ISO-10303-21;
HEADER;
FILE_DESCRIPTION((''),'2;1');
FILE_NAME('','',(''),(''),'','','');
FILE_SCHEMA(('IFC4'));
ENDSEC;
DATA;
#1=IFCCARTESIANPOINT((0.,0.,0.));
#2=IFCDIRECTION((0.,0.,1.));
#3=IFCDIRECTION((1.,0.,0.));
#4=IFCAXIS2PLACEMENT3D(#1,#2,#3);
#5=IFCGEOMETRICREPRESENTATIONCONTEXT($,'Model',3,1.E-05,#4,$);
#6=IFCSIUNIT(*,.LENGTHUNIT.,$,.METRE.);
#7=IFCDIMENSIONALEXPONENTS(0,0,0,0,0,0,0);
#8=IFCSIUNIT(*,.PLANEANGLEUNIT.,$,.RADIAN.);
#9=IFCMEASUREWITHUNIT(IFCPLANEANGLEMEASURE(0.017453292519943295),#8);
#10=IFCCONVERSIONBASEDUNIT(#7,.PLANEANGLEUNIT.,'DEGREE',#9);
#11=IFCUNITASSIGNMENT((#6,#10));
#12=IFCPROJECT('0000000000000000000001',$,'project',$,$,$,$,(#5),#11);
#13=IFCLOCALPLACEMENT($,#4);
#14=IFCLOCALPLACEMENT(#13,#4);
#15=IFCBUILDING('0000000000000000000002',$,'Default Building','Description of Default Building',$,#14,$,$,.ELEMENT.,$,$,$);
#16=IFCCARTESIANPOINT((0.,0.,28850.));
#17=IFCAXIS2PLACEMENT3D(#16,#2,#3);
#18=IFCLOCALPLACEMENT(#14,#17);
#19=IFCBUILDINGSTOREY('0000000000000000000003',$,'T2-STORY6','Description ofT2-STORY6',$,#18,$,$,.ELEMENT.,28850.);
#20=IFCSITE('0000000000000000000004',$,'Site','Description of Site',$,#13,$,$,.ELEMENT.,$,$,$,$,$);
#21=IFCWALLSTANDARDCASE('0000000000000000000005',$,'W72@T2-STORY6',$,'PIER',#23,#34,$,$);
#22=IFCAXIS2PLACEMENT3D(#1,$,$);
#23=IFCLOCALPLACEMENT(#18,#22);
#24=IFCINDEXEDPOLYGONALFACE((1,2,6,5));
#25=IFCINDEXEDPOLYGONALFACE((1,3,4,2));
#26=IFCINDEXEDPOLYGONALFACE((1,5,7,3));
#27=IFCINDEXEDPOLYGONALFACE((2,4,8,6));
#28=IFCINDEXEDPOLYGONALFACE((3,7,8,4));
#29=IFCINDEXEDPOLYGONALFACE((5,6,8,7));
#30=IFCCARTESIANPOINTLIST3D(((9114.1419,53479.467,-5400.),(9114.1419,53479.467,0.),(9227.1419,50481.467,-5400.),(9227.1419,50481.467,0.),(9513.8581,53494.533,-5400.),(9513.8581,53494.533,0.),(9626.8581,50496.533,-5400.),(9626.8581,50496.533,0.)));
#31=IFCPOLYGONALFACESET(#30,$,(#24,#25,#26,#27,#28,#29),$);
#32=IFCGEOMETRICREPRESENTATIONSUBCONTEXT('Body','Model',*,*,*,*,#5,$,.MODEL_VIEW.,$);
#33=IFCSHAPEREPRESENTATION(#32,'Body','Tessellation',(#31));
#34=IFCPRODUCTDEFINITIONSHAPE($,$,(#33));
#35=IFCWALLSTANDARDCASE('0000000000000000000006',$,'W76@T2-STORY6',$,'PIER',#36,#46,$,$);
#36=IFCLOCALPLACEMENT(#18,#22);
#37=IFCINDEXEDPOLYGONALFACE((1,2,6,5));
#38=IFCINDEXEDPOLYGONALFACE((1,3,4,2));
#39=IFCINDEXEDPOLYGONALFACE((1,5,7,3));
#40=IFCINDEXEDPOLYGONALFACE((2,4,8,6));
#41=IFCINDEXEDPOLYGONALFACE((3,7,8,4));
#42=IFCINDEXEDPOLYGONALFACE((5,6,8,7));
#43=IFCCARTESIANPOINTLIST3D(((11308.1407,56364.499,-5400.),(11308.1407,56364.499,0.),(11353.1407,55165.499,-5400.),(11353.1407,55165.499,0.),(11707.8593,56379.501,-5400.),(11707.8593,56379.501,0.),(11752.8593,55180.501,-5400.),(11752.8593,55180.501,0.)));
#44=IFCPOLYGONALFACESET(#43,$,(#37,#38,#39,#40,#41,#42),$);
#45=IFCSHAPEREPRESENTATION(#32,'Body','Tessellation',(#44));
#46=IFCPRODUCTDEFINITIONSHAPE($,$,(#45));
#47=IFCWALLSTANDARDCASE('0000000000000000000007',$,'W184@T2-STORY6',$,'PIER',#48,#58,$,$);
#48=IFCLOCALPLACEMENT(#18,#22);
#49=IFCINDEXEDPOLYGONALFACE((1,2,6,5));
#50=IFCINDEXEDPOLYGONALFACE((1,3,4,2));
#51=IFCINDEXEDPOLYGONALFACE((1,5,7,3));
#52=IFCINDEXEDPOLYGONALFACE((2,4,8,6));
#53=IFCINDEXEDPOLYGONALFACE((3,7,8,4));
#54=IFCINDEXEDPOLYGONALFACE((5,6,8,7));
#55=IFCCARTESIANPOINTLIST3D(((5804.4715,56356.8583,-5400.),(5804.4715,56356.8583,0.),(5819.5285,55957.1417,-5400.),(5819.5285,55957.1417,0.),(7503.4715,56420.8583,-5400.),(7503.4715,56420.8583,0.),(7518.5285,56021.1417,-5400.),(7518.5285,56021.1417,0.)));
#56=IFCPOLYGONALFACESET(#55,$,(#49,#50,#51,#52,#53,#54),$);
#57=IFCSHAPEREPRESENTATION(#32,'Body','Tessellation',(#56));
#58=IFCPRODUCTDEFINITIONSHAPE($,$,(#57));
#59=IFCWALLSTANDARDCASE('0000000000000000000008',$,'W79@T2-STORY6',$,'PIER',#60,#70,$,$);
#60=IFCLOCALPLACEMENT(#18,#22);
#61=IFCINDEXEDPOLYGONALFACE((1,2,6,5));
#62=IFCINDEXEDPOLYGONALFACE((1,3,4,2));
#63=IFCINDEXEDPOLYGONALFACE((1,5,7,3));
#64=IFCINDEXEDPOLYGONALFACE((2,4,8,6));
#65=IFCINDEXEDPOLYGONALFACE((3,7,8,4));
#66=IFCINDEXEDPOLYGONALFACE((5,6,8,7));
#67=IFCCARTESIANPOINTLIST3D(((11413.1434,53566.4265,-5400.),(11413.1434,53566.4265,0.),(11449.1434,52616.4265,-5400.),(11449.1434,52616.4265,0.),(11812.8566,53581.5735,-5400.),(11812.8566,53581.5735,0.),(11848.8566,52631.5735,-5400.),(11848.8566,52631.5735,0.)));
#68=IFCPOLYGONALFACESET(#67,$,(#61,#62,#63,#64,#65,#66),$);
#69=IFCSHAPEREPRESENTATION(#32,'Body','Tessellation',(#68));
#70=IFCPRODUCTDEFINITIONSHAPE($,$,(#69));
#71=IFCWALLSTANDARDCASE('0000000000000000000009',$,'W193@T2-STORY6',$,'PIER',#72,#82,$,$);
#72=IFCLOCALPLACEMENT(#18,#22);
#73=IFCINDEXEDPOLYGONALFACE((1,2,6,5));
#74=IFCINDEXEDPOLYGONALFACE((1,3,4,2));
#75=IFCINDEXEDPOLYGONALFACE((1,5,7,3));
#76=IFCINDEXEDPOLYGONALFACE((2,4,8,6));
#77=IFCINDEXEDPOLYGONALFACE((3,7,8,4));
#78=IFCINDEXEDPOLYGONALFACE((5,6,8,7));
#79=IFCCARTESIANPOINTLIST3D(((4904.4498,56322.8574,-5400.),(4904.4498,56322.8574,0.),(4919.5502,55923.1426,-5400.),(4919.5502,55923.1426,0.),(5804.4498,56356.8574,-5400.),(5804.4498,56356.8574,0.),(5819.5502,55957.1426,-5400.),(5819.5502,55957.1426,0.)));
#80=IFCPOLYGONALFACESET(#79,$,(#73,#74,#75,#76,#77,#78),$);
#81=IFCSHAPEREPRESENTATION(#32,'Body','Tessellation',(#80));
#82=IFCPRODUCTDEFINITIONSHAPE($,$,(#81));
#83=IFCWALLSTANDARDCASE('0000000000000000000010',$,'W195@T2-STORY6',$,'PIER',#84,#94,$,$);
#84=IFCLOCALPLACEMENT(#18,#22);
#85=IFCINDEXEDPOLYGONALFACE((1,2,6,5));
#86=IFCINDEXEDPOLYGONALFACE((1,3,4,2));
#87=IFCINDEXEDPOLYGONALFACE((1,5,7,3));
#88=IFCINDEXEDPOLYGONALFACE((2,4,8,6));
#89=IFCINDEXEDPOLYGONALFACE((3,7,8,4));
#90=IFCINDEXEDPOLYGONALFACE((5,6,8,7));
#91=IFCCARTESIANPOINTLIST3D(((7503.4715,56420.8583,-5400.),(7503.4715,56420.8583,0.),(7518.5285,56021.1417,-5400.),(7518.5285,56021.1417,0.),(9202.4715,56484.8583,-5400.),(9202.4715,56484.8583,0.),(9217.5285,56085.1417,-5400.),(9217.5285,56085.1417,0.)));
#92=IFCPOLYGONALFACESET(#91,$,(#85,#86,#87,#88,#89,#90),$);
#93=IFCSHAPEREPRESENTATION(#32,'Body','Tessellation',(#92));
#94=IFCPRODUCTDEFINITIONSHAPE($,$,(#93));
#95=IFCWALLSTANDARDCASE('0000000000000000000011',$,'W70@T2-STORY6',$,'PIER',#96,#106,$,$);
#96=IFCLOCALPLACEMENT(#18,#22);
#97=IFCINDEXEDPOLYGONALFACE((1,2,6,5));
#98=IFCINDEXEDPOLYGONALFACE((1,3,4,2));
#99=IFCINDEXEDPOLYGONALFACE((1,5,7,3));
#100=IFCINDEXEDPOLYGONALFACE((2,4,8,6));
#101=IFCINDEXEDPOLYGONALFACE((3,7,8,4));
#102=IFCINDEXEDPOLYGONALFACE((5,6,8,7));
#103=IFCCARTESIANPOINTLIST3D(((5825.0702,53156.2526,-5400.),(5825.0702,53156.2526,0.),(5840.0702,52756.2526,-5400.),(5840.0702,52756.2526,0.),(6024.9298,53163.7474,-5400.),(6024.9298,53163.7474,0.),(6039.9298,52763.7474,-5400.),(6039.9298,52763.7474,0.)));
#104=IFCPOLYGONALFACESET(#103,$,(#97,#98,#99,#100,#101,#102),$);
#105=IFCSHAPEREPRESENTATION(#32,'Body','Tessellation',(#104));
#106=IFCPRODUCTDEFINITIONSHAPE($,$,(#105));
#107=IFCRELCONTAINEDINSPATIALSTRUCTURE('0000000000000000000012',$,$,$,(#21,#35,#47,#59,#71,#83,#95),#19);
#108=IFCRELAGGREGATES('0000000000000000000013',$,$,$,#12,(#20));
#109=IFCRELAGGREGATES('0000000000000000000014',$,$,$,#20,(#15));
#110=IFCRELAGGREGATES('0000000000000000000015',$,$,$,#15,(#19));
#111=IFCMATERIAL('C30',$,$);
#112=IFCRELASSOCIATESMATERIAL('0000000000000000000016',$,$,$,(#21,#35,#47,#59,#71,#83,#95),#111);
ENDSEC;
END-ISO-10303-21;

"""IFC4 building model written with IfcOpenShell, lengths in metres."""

from ifc_helpers import new_model, entity, si_unit, converted_unit, frame, origin_with_axes, place, context, subcontext, project, spatial, indexed_curve, outline, extrude, material, element, save


model = new_model("IFC4")

# Units and contexts
model_context = context("Model", 3, precision=1e-05, world=origin_with_axes())
body_context = subcontext(model_context, "Body", "Model", "MODEL_VIEW")
ifc_project = project(units=[si_unit("LENGTHUNIT", "METRE"), converted_unit("PLANEANGLEUNIT", "DEGREE", entity("IfcPlaneAngleMeasure", 0.017453292519943295), si_unit("PLANEANGLEUNIT", "RADIAN"), dimensions=[0, 0, 0, 0, 0, 0, 0])], contexts=[model_context])

# Site, building, storey
site_placement = place(None, origin_with_axes())
site = spatial("IfcSite", under=ifc_project, at=site_placement, Name="Site", Description="Description of Site", CompositionType="ELEMENT")
building_placement = place(site_placement, origin_with_axes())
building = spatial("IfcBuilding", under=site, at=building_placement, Name="Default Building", Description="Description of Default Building", CompositionType="ELEMENT")
storey_placement = place(building_placement, frame((0.0, 0.0, 28850.0), z_axis=(0.0, 0.0, 1.0), x_axis=(1.0, 0.0, 0.0)))
storey = spatial("IfcBuildingStorey", under=building, at=storey_placement, Name="T2-STORY6", Description="Description ofT2-STORY6", CompositionType="ELEMENT", Elevation=28850.0)

# Shared definitions
ifc_material = material(Name="C30")

# Walls
wall_1_placement = place(storey_placement, frame((9314.0, 53487.0, -5400.0), z_axis=(0.0, 0.0, 1.0), x_axis=(0.037665, -0.99929, 0.0)))
element("IfcWallStandardCase", 1, at=wall_1_placement, inside=storey, material=ifc_material, Name="W72@T2-STORY6", ObjectType="PIER", context=body_context, shape_type="SweptSolid", body=[
    extrude(outline(indexed_curve([(0.0, -200.0), (0.0, 200.0), (3000.1288, 200.0), (3000.1288, -200.0), (0.0, -200.0)], self_intersect=False)), origin_with_axes(), (0.0, 0.0, 1.0), 5400.0),
])
wall_2_placement = place(storey_placement, frame((11508.0, 56372.0, -5400.0), z_axis=(0.0, 0.0, 1.0), x_axis=(0.037505, -0.999296, 0.0)))
element("IfcWallStandardCase", 2, at=wall_2_placement, inside=storey, material=ifc_material, Name="W76@T2-STORY6", ObjectType="PIER", context=body_context, shape_type="SweptSolid", body=[
    extrude(outline(indexed_curve([(0.0, -200.0), (0.0, 200.0), (1199.8442, 200.0), (1199.8442, -200.0), (0.0, -200.0)], self_intersect=False)), origin_with_axes(), (0.0, 0.0, 1.0), 5400.0),
])
wall_3_placement = place(storey_placement, frame((5812.0, 56157.0, -5400.0), z_axis=(0.0, 0.0, 1.0), x_axis=(0.999291, 0.037643, 0.0)))
element("IfcWallStandardCase", 3, at=wall_3_placement, inside=storey, material=ifc_material, Name="W184@T2-STORY6", ObjectType="PIER", context=body_context, shape_type="SweptSolid", body=[
    extrude(outline(indexed_curve([(0.0, -200.0), (0.0, 200.0), (1700.205, 200.0), (1700.205, -200.0), (0.0, -200.0)], self_intersect=False)), origin_with_axes(), (0.0, 0.0, 1.0), 5400.0),
])
wall_4_placement = place(storey_placement, frame((11613.0, 53574.0, -5400.0), z_axis=(0.0, 0.0, 1.0), x_axis=(0.037868, -0.999283, 0.0)))
element("IfcWallStandardCase", 4, at=wall_4_placement, inside=storey, material=ifc_material, Name="W79@T2-STORY6", ObjectType="PIER", context=body_context, shape_type="SweptSolid", body=[
    extrude(outline(indexed_curve([(0.0, -200.0), (0.0, 200.0), (950.6819, 200.0), (950.6819, -200.0), (0.0, -200.0)], self_intersect=False)), origin_with_axes(), (0.0, 0.0, 1.0), 5400.0),
])
wall_5_placement = place(storey_placement, frame((4912.0, 56123.0, -5400.0), z_axis=(0.0, 0.0, 1.0), x_axis=(0.999287, 0.037751, 0.0)))
element("IfcWallStandardCase", 5, at=wall_5_placement, inside=storey, material=ifc_material, Name="W193@T2-STORY6", ObjectType="PIER", context=body_context, shape_type="SweptSolid", body=[
    extrude(outline(indexed_curve([(0.0, -200.0), (0.0, 200.0), (900.642, 200.0), (900.642, -200.0), (0.0, -200.0)], self_intersect=False)), origin_with_axes(), (0.0, 0.0, 1.0), 5400.0),
])
wall_6_placement = place(storey_placement, frame((7511.0, 56221.0, -5400.0), z_axis=(0.0, 0.0, 1.0), x_axis=(0.999291, 0.037643, 0.0)))
element("IfcWallStandardCase", 6, at=wall_6_placement, inside=storey, material=ifc_material, Name="W195@T2-STORY6", ObjectType="PIER", context=body_context, shape_type="SweptSolid", body=[
    extrude(outline(indexed_curve([(0.0, -200.0), (0.0, 200.0), (1700.205, 200.0), (1700.205, -200.0), (0.0, -200.0)], self_intersect=False)), origin_with_axes(), (0.0, 0.0, 1.0), 5400.0),
])
wall_7_placement = place(storey_placement, frame((5925.0, 53160.0, -5400.0), z_axis=(0.0, 0.0, 1.0), x_axis=(0.037474, -0.999298, 0.0)))
element("IfcWallStandardCase", 7, at=wall_7_placement, inside=storey, material=ifc_material, Name="W70@T2-STORY6", ObjectType="PIER", context=body_context, shape_type="SweptSolid", body=[
    extrude(outline(indexed_curve([(0.0, -100.0), (0.0, 100.0), (400.2812, 100.0), (400.2812, -100.0), (0.0, -100.0)], self_intersect=False)), origin_with_axes(), (0.0, 0.0, 1.0), 5400.0),
])

save(model, "model.ifc")
